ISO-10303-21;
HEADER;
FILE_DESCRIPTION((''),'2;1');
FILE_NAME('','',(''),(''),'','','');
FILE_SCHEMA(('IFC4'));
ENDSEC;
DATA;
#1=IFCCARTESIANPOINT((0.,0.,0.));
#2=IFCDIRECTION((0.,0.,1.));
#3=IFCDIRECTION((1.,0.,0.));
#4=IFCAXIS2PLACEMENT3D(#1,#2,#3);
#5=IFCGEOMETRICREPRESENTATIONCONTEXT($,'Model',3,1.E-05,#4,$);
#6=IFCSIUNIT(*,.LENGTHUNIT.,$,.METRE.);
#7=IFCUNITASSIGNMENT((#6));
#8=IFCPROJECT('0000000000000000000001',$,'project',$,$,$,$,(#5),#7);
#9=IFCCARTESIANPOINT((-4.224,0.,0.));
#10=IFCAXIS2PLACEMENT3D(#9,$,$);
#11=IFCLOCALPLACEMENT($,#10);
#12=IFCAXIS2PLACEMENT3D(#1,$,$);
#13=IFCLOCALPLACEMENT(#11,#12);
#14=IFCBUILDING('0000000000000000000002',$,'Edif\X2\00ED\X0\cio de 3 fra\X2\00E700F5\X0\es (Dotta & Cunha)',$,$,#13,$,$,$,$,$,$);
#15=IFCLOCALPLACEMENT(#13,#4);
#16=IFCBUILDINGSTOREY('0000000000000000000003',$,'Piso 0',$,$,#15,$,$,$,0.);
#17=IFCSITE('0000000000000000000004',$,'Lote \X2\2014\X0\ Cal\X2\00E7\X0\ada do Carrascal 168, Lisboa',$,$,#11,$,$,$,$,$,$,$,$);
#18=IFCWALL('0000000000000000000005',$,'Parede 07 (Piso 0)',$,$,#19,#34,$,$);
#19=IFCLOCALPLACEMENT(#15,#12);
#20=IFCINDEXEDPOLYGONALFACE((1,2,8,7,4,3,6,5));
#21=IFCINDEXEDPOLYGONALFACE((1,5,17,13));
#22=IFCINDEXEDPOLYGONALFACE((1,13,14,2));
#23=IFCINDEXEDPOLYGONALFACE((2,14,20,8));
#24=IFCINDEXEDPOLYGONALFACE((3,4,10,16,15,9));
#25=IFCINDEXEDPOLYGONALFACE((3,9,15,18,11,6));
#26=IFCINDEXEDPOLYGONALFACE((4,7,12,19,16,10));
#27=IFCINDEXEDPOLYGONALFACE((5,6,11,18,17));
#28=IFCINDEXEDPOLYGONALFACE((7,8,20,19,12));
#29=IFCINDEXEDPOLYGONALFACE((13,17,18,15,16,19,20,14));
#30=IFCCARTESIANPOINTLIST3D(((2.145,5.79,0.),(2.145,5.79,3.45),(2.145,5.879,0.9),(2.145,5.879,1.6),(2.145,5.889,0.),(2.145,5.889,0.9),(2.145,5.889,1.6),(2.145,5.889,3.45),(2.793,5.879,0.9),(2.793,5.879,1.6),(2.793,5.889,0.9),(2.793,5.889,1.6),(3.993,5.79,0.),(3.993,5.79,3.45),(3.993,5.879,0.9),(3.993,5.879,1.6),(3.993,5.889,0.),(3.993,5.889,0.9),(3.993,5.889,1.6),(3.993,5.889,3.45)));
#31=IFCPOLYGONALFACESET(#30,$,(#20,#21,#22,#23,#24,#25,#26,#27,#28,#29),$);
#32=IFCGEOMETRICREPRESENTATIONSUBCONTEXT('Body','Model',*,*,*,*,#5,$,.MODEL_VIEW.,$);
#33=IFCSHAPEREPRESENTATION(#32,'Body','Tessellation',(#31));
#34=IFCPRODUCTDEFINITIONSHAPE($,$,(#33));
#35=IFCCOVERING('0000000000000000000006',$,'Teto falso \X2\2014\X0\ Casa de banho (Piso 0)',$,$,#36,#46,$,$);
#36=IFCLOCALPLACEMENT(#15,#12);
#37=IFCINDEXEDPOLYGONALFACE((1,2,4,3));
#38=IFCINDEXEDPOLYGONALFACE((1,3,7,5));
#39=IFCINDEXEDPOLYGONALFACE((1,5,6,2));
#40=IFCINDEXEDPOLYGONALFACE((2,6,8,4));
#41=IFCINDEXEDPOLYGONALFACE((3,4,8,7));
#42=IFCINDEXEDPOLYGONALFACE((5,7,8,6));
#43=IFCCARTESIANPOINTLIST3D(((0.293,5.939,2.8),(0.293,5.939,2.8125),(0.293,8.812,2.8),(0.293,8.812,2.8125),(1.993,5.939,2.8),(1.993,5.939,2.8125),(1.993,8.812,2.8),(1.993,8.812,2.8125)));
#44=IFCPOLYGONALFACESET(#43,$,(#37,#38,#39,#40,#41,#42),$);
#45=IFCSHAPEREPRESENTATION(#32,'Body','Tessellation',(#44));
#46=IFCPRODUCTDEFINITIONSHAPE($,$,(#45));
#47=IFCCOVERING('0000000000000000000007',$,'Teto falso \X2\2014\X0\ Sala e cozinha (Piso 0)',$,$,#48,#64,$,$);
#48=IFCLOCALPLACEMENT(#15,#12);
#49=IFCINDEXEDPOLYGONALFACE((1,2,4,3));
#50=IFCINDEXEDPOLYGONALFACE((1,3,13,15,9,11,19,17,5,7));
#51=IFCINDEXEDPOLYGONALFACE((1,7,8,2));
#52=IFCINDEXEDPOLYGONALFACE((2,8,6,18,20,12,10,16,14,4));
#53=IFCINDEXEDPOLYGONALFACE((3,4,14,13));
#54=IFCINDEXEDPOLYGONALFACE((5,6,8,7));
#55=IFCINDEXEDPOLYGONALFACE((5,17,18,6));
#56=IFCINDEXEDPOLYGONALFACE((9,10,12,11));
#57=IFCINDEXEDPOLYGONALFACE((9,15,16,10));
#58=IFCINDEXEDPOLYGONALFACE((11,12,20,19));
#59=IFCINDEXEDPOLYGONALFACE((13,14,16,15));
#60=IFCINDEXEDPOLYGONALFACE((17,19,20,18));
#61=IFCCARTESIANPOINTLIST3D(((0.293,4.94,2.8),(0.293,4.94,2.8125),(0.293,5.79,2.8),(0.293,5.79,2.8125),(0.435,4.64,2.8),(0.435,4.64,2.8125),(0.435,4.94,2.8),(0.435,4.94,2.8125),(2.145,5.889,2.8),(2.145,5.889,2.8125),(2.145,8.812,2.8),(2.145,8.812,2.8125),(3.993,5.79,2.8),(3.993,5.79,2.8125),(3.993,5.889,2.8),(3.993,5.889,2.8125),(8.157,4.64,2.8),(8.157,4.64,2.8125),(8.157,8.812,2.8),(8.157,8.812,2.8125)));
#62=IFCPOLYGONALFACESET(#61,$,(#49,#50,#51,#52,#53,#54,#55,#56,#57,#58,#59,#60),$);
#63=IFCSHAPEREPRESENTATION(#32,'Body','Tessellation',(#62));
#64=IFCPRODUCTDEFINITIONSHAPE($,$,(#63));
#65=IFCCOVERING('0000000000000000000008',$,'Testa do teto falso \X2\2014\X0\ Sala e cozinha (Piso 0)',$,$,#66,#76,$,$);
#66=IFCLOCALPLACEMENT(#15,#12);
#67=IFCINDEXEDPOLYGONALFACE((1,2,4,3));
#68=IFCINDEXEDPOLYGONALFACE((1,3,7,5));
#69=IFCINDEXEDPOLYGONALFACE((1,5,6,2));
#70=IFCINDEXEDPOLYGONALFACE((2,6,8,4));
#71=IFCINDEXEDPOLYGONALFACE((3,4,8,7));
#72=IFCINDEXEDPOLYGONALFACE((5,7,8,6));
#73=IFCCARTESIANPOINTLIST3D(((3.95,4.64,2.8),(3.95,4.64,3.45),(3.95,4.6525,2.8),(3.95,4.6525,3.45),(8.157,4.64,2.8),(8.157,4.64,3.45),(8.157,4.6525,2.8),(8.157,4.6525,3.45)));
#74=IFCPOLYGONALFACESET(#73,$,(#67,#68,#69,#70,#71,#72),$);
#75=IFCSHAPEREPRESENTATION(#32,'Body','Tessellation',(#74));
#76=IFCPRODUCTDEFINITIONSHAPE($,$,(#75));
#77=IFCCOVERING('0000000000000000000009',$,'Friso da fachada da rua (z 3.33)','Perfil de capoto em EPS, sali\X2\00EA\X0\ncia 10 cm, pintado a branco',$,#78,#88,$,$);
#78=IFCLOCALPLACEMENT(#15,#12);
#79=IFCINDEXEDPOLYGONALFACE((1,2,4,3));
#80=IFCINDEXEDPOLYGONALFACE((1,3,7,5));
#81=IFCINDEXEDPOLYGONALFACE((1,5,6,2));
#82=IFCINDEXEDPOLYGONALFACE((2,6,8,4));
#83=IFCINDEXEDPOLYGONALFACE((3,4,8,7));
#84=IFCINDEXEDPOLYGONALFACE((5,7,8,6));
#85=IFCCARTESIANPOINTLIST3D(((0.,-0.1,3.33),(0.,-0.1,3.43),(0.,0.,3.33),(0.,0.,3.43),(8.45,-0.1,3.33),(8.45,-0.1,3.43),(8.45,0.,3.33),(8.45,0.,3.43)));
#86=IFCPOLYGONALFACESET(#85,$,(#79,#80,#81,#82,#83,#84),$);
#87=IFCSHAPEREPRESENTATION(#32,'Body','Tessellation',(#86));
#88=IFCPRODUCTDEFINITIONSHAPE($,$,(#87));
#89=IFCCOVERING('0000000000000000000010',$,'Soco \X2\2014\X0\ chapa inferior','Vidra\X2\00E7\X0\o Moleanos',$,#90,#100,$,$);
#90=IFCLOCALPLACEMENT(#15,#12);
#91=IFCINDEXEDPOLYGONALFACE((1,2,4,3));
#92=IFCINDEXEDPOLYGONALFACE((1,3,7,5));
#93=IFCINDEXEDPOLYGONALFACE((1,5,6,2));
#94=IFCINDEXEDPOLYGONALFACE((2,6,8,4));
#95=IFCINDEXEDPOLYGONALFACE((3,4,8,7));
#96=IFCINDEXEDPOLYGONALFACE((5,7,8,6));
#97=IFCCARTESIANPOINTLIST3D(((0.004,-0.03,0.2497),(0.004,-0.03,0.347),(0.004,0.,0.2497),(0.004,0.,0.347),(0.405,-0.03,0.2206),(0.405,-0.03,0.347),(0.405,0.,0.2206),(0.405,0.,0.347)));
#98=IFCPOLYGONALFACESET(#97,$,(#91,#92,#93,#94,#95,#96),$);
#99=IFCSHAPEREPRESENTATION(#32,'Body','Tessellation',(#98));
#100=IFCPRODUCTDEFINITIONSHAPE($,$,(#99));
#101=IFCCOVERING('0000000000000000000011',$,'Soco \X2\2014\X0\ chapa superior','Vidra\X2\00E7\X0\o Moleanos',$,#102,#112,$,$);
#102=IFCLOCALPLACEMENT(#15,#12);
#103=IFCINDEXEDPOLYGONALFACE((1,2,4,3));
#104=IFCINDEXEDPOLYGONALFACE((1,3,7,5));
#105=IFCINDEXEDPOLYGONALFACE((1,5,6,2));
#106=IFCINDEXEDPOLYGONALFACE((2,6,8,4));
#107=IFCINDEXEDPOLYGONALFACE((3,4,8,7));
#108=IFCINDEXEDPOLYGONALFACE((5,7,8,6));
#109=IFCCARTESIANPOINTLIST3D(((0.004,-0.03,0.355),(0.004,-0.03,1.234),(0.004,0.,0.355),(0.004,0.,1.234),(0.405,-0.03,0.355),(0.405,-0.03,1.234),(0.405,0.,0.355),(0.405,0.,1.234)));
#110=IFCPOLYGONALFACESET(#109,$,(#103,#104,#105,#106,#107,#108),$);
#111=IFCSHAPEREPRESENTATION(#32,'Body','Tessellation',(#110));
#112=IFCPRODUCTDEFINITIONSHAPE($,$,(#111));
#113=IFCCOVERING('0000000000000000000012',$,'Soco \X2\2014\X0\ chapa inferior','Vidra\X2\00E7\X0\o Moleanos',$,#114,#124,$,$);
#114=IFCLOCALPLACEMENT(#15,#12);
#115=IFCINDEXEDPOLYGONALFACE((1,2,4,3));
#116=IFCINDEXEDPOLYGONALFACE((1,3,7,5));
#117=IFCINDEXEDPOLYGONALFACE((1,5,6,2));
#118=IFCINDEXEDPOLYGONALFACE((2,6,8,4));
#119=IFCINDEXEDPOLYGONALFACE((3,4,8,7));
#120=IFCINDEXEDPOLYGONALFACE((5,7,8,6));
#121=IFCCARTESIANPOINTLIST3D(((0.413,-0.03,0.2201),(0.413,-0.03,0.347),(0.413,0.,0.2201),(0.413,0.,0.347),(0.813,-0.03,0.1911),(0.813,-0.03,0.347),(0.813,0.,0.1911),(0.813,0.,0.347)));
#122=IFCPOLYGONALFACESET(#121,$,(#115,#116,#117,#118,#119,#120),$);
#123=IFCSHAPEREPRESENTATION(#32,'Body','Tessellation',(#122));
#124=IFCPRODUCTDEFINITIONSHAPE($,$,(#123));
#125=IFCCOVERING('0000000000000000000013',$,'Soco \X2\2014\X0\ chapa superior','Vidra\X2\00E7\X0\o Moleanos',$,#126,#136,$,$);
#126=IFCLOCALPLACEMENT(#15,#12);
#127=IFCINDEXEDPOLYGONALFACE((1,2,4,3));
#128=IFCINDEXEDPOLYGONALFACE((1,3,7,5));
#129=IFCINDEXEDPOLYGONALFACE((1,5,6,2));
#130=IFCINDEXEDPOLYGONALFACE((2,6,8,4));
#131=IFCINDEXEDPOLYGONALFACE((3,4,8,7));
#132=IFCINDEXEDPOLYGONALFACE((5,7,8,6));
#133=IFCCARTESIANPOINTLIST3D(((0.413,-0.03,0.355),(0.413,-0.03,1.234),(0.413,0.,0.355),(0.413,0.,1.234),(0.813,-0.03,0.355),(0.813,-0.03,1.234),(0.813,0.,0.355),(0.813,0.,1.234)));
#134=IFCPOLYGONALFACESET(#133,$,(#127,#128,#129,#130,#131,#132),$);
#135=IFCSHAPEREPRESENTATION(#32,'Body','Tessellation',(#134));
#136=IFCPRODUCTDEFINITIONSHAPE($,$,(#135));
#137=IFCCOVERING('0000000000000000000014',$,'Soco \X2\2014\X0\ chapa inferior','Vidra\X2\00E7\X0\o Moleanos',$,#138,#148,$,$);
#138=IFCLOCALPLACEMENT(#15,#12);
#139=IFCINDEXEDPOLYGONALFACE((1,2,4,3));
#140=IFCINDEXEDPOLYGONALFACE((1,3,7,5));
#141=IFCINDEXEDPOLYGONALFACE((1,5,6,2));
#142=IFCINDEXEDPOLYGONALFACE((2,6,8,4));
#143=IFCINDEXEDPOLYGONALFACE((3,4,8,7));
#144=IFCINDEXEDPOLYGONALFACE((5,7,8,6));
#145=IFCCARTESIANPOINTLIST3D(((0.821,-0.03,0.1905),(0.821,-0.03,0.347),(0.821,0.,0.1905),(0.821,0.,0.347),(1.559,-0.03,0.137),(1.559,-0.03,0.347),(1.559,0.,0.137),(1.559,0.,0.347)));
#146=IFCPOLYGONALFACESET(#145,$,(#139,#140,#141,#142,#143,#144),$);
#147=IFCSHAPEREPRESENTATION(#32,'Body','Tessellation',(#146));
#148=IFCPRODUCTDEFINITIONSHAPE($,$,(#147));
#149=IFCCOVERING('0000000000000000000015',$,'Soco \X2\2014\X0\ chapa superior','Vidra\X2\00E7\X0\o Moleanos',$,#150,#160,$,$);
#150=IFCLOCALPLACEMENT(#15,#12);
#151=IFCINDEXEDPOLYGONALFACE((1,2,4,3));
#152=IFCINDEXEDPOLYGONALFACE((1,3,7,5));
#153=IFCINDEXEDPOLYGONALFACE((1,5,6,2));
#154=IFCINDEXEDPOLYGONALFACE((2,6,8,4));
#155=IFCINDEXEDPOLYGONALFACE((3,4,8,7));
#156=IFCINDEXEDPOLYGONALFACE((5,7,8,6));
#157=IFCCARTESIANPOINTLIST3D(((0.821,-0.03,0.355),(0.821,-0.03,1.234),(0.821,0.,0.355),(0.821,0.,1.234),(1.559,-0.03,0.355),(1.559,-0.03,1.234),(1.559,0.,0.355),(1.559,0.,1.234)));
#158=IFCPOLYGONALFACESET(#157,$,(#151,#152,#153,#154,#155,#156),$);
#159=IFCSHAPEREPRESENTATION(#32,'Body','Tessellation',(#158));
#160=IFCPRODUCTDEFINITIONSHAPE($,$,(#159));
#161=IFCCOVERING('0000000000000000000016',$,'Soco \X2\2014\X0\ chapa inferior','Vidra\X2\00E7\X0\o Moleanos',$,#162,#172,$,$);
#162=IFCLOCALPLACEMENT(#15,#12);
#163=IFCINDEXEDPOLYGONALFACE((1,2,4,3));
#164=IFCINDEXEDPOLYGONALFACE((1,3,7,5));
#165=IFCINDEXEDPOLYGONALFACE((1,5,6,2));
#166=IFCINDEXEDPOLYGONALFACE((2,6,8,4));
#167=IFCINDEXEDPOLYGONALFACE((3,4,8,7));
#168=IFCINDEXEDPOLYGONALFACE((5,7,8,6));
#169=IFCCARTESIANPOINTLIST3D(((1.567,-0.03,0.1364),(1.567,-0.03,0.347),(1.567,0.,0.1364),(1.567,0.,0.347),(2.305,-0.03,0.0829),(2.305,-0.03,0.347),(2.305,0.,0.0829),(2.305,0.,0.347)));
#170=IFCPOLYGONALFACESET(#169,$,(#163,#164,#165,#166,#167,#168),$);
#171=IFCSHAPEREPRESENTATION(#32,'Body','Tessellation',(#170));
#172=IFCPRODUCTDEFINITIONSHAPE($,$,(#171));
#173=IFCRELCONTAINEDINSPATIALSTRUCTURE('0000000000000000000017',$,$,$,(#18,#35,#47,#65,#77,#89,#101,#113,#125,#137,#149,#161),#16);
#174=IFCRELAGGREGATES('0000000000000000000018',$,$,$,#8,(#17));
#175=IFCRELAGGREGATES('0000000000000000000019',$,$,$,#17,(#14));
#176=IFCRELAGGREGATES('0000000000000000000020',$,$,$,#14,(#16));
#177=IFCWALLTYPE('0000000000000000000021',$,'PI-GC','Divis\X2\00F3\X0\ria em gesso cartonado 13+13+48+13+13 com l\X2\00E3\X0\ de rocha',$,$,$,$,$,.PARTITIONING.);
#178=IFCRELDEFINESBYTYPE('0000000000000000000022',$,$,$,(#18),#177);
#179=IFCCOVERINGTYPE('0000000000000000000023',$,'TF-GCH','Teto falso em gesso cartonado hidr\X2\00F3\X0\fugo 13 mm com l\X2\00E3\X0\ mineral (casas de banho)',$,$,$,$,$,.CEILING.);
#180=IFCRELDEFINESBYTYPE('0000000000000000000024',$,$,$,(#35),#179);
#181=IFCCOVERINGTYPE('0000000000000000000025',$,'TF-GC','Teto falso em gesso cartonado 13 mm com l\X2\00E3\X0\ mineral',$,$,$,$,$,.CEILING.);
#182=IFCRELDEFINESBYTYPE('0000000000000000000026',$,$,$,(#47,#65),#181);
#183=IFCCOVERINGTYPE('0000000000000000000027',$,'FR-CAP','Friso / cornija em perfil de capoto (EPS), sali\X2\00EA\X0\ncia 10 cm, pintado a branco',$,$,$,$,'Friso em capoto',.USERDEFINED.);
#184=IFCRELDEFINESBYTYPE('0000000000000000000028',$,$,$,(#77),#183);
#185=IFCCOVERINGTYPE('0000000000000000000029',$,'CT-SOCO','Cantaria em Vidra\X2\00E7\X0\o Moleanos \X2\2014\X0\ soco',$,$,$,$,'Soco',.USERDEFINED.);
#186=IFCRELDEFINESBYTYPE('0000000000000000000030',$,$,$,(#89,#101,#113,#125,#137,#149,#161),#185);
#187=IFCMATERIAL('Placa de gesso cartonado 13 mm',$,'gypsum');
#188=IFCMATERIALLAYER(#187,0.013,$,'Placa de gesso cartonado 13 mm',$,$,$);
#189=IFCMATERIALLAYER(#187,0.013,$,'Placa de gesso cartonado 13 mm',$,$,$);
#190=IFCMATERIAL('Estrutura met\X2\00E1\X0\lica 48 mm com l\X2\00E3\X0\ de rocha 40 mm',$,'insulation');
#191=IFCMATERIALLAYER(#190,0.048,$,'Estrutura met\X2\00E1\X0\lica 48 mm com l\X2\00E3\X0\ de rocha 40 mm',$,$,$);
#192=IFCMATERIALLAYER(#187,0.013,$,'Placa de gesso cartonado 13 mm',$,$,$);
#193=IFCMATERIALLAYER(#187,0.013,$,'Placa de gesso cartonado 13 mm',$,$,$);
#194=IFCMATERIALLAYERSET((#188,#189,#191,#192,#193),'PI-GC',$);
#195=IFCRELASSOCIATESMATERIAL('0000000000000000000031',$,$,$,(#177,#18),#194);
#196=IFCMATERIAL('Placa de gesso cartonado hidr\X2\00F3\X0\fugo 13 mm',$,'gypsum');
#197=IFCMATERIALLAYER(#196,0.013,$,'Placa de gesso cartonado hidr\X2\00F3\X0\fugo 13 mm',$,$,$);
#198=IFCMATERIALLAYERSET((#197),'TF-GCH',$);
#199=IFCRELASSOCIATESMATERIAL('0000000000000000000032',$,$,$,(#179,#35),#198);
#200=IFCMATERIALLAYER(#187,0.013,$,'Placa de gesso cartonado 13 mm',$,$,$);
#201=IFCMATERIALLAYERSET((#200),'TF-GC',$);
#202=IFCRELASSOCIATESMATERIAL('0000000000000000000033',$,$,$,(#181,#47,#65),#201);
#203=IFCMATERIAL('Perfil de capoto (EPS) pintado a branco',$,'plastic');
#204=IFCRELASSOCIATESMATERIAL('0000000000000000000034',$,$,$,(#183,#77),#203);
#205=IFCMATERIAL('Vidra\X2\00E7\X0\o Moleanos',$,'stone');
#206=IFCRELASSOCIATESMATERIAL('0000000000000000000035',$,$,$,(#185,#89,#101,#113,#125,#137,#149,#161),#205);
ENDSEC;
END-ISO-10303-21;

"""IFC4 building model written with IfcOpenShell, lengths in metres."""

from ifc_helpers import new_model, si_unit, frame, origin, origin_with_axes, place, context, subcontext, project, spatial, line, indexed_curve, outline, extrude, material, layer, layer_set, layer_usage, type_object, element, save


model = new_model("IFC4")

# Units and contexts
model_context = context("Model", 3, precision=1e-05, world=origin_with_axes())
body_context = subcontext(model_context, "Body", "Model", "MODEL_VIEW")
ifc_project = project(units=[si_unit("LENGTHUNIT", "METRE")], contexts=[model_context])

# Site, building, storey
site_placement = place(None, frame((-4.224, 0.0, 0.0)))
site = spatial("IfcSite", under=ifc_project, at=site_placement, Name="Lote — Calçada do Carrascal 168, Lisboa")
building_placement = place(site_placement, origin())
building = spatial("IfcBuilding", under=site, at=building_placement, Name="Edifício de 3 frações (Dotta & Cunha)")
storey_placement = place(building_placement, origin_with_axes())
storey = spatial("IfcBuildingStorey", under=building, at=storey_placement, Name="Piso 0", Elevation=0.0)

# Wall, openings
ifc_material_1 = material(Name="Placa de gesso cartonado 13 mm", Category="gypsum")
ifc_layer_1 = layer(ifc_material_1, 0.013, Name="Placa de gesso cartonado 13 mm")
ifc_layer_2 = layer(ifc_material_1, 0.013, Name="Placa de gesso cartonado 13 mm")
ifc_material_2 = material(Name="Estrutura metálica 48 mm com lã de rocha 40 mm", Category="insulation")
ifc_layer_3 = layer(ifc_material_2, 0.048, Name="Estrutura metálica 48 mm com lã de rocha 40 mm")
ifc_layer_4 = layer(ifc_material_1, 0.013, Name="Placa de gesso cartonado 13 mm")
ifc_layer_5 = layer(ifc_material_1, 0.013, Name="Placa de gesso cartonado 13 mm")
ifc_layer_set_1 = layer_set([ifc_layer_1, ifc_layer_2, ifc_layer_3, ifc_layer_4, ifc_layer_5], Name="PI-GC")
ifc_layer_usage_1 = layer_usage(ifc_layer_set_1, "AXIS2", "POSITIVE", 0.0)
wall_type_1 = type_object("IfcWallType", Name="PI-GC", Description="Divisória em gesso cartonado 13+13+48+13+13 com lã de rocha", PredefinedType="PARTITIONING", material=ifc_layer_set_1)
wall_1_placement = place(storey_placement, origin_with_axes())
wall_1 = element("IfcWall", 1, at=wall_1_placement, inside=storey, type_object=wall_type_1, material=ifc_layer_usage_1, Name="Parede 07 (Piso 0)", context=body_context, shape_type="SweptSolid", body=[
    extrude(outline(indexed_curve([(3.993, 5.79), (3.993, 5.889), (2.145, 5.889), (2.145, 5.79)], segments=[line(1, 2, 3, 4, 1)])), origin_with_axes(), (0.0, 0.0, 1.0), 3.45),
])
opening_1_placement = place(wall_1_placement, frame((0.0, 0.0, 0.9), z_axis=(0.0, 0.0, 1.0), x_axis=(1.0, 0.0, 0.0)))
element("IfcOpeningElement", 2, at=opening_1_placement, cuts=wall_1, PredefinedType="RECESS", context=body_context, shape_type="SweptSolid", body=[
    extrude(outline(indexed_curve([(2.793, 5.879), (2.793, 5.894), (2.145, 5.894), (2.145, 5.879)], segments=[line(1, 2, 3, 4, 1)])), origin_with_axes(), (0.0, 0.0, 1.0), 0.7),
])
opening_2_placement = place(wall_1_placement, frame((0.0, 0.0, 0.9), z_axis=(0.0, 0.0, 1.0), x_axis=(1.0, 0.0, 0.0)))
element("IfcOpeningElement", 3, at=opening_2_placement, cuts=wall_1, PredefinedType="RECESS", context=body_context, shape_type="SweptSolid", body=[
    extrude(outline(indexed_curve([(3.993, 5.879), (3.993, 5.894), (2.793, 5.894), (2.793, 5.879)], segments=[line(1, 2, 3, 4, 1)])), origin_with_axes(), (0.0, 0.0, 1.0), 0.7),
])

# Coverings
ifc_material_3 = material(Name="Placa de gesso cartonado hidrófugo 13 mm", Category="gypsum")
ifc_layer_6 = layer(ifc_material_3, 0.013, Name="Placa de gesso cartonado hidrófugo 13 mm")
ifc_layer_set_2 = layer_set([ifc_layer_6], Name="TF-GCH")
ifc_layer_usage_2 = layer_usage(ifc_layer_set_2, "AXIS3", "POSITIVE", 0.0)
covering_type_1 = type_object("IfcCoveringType", Name="TF-GCH", Description="Teto falso em gesso cartonado hidrófugo 13 mm com lã mineral (casas de banho)", PredefinedType="CEILING", material=ifc_layer_set_2)
covering_1_placement = place(storey_placement, frame((0.0, 0.0, 2.8), z_axis=(0.0, 0.0, 1.0), x_axis=(1.0, 0.0, 0.0)))
element("IfcCovering", 4, at=covering_1_placement, inside=storey, type_object=covering_type_1, material=ifc_layer_usage_2, Name="Teto falso — Casa de banho (Piso 0)", context=body_context, shape_type="SweptSolid", body=[
    extrude(outline(indexed_curve([(0.293, 8.812), (1.993, 8.812), (1.993, 5.939), (0.293, 5.939)], segments=[line(1, 2, 3, 4, 1)])), origin_with_axes(), (0.0, 0.0, 1.0), 0.0125),
])
ifc_layer_7 = layer(ifc_material_1, 0.013, Name="Placa de gesso cartonado 13 mm")
ifc_layer_set_3 = layer_set([ifc_layer_7], Name="TF-GC")
ifc_layer_usage_3 = layer_usage(ifc_layer_set_3, "AXIS3", "POSITIVE", 0.0)
covering_type_2 = type_object("IfcCoveringType", Name="TF-GC", Description="Teto falso em gesso cartonado 13 mm com lã mineral", PredefinedType="CEILING", material=ifc_layer_set_3)
covering_2_placement = place(storey_placement, frame((0.0, 0.0, 2.8), z_axis=(0.0, 0.0, 1.0), x_axis=(1.0, 0.0, 0.0)))
element("IfcCovering", 5, at=covering_2_placement, inside=storey, type_object=covering_type_2, material=ifc_layer_usage_3, Name="Teto falso — Sala e cozinha (Piso 0)", context=body_context, shape_type="SweptSolid", body=[
    extrude(outline(indexed_curve([(8.157, 4.64), (0.435, 4.64), (0.435, 4.94), (0.293, 4.94), (0.293, 5.79), (3.993, 5.79), (3.993, 5.889), (2.145, 5.889), (2.145, 8.812), (8.157, 8.812)], segments=[line(1, 2, 3, 4, 5, 6, 7, 8, 9, 10, 1)])), origin_with_axes(), (0.0, 0.0, 1.0), 0.0125),
])
ifc_layer_usage_4 = layer_usage(ifc_layer_set_3, "AXIS3", "POSITIVE", 0.0)
covering_3_placement = place(storey_placement, frame((0.0, 0.0, 2.8), z_axis=(0.0, 0.0, 1.0), x_axis=(1.0, 0.0, 0.0)))
element("IfcCovering", 6, at=covering_3_placement, inside=storey, type_object=covering_type_2, material=ifc_layer_usage_4, Name="Testa do teto falso — Sala e cozinha (Piso 0)", context=body_context, shape_type="SweptSolid", body=[
    extrude(outline(indexed_curve([(8.157, 4.64), (8.157, 4.6525), (3.95, 4.6525), (3.95, 4.64)], segments=[line(1, 2, 3, 4, 1)])), origin_with_axes(), (0.0, 0.0, 1.0), 0.65),
])
ifc_material_4 = material(Name="Perfil de capoto (EPS) pintado a branco", Category="plastic")
covering_type_3 = type_object("IfcCoveringType", Name="FR-CAP", Description="Friso / cornija em perfil de capoto (EPS), saliência 10 cm, pintado a branco", ElementType="Friso em capoto", PredefinedType="USERDEFINED", material=ifc_material_4)
covering_4_placement = place(storey_placement, frame((0.0, 0.0, 0.0), z_axis=(0.0, -1.0, 0.0), x_axis=(1.0, 0.0, 0.0)))
element("IfcCovering", 7, at=covering_4_placement, inside=storey, type_object=covering_type_3, material=ifc_material_4, Name="Friso da fachada da rua (z 3.33)", Description="Perfil de capoto em EPS, saliência 10 cm, pintado a branco", context=body_context, shape_type="SweptSolid", body=[
    extrude(outline(indexed_curve([(8.45, 3.33), (8.45, 3.43), (0.0, 3.43), (0.0, 3.33)], segments=[line(1, 2, 3, 4, 1)])), origin_with_axes(), (0.0, 0.0, 1.0), 0.1),
])
ifc_material_5 = material(Name="Vidraço Moleanos", Category="stone")
covering_type_4 = type_object("IfcCoveringType", Name="CT-SOCO", Description="Cantaria em Vidraço Moleanos — soco", ElementType="Soco", PredefinedType="USERDEFINED", material=ifc_material_5)
covering_5_placement = place(storey_placement, frame((0.0, 0.0, 0.0), z_axis=(0.0, -1.0, 0.0), x_axis=(1.0, 0.0, 0.0)))
element("IfcCovering", 8, at=covering_5_placement, inside=storey, type_object=covering_type_4, material=ifc_material_5, Name="Soco — chapa inferior", Description="Vidraço Moleanos", context=body_context, shape_type="SweptSolid", body=[
    extrude(outline(indexed_curve([(0.004, 0.2497), (0.405, 0.2206), (0.405, 0.347), (0.004, 0.347)], segments=[line(1, 2, 3, 4, 1)])), origin_with_axes(), (0.0, 0.0, 1.0), 0.03),
])
covering_6_placement = place(storey_placement, frame((0.0, 0.0, 0.0), z_axis=(0.0, -1.0, 0.0), x_axis=(1.0, 0.0, 0.0)))
element("IfcCovering", 9, at=covering_6_placement, inside=storey, type_object=covering_type_4, material=ifc_material_5, Name="Soco — chapa superior", Description="Vidraço Moleanos", context=body_context, shape_type="SweptSolid", body=[
    extrude(outline(indexed_curve([(0.405, 0.355), (0.405, 1.234), (0.004, 1.234), (0.004, 0.355)], segments=[line(1, 2, 3, 4, 1)])), origin_with_axes(), (0.0, 0.0, 1.0), 0.03),
])
covering_7_placement = place(storey_placement, frame((0.0, 0.0, 0.0), z_axis=(0.0, -1.0, 0.0), x_axis=(1.0, 0.0, 0.0)))
element("IfcCovering", 10, at=covering_7_placement, inside=storey, type_object=covering_type_4, material=ifc_material_5, Name="Soco — chapa inferior", Description="Vidraço Moleanos", context=body_context, shape_type="SweptSolid", body=[
    extrude(outline(indexed_curve([(0.413, 0.2201), (0.813, 0.1911), (0.813, 0.347), (0.413, 0.347)], segments=[line(1, 2, 3, 4, 1)])), origin_with_axes(), (0.0, 0.0, 1.0), 0.03),
])
covering_8_placement = place(storey_placement, frame((0.0, 0.0, 0.0), z_axis=(0.0, -1.0, 0.0), x_axis=(1.0, 0.0, 0.0)))
element("IfcCovering", 11, at=covering_8_placement, inside=storey, type_object=covering_type_4, material=ifc_material_5, Name="Soco — chapa superior", Description="Vidraço Moleanos", context=body_context, shape_type="SweptSolid", body=[
    extrude(outline(indexed_curve([(0.813, 0.355), (0.813, 1.234), (0.413, 1.234), (0.413, 0.355)], segments=[line(1, 2, 3, 4, 1)])), origin_with_axes(), (0.0, 0.0, 1.0), 0.03),
])
covering_9_placement = place(storey_placement, frame((0.0, 0.0, 0.0), z_axis=(0.0, -1.0, 0.0), x_axis=(1.0, 0.0, 0.0)))
element("IfcCovering", 12, at=covering_9_placement, inside=storey, type_object=covering_type_4, material=ifc_material_5, Name="Soco — chapa inferior", Description="Vidraço Moleanos", context=body_context, shape_type="SweptSolid", body=[
    extrude(outline(indexed_curve([(0.821, 0.1905), (1.559, 0.137), (1.559, 0.347), (0.821, 0.347)], segments=[line(1, 2, 3, 4, 1)])), origin_with_axes(), (0.0, 0.0, 1.0), 0.03),
])
covering_10_placement = place(storey_placement, frame((0.0, 0.0, 0.0), z_axis=(0.0, -1.0, 0.0), x_axis=(1.0, 0.0, 0.0)))
element("IfcCovering", 13, at=covering_10_placement, inside=storey, type_object=covering_type_4, material=ifc_material_5, Name="Soco — chapa superior", Description="Vidraço Moleanos", context=body_context, shape_type="SweptSolid", body=[
    extrude(outline(indexed_curve([(1.559, 0.355), (1.559, 1.234), (0.821, 1.234), (0.821, 0.355)], segments=[line(1, 2, 3, 4, 1)])), origin_with_axes(), (0.0, 0.0, 1.0), 0.03),
])
covering_11_placement = place(storey_placement, frame((0.0, 0.0, 0.0), z_axis=(0.0, -1.0, 0.0), x_axis=(1.0, 0.0, 0.0)))
element("IfcCovering", 14, at=covering_11_placement, inside=storey, type_object=covering_type_4, material=ifc_material_5, Name="Soco — chapa inferior", Description="Vidraço Moleanos", context=body_context, shape_type="SweptSolid", body=[
    extrude(outline(indexed_curve([(1.567, 0.1364), (2.305, 0.0829), (2.305, 0.347), (1.567, 0.347)], segments=[line(1, 2, 3, 4, 1)])), origin_with_axes(), (0.0, 0.0, 1.0), 0.03),
])

save(model, "model.ifc")
